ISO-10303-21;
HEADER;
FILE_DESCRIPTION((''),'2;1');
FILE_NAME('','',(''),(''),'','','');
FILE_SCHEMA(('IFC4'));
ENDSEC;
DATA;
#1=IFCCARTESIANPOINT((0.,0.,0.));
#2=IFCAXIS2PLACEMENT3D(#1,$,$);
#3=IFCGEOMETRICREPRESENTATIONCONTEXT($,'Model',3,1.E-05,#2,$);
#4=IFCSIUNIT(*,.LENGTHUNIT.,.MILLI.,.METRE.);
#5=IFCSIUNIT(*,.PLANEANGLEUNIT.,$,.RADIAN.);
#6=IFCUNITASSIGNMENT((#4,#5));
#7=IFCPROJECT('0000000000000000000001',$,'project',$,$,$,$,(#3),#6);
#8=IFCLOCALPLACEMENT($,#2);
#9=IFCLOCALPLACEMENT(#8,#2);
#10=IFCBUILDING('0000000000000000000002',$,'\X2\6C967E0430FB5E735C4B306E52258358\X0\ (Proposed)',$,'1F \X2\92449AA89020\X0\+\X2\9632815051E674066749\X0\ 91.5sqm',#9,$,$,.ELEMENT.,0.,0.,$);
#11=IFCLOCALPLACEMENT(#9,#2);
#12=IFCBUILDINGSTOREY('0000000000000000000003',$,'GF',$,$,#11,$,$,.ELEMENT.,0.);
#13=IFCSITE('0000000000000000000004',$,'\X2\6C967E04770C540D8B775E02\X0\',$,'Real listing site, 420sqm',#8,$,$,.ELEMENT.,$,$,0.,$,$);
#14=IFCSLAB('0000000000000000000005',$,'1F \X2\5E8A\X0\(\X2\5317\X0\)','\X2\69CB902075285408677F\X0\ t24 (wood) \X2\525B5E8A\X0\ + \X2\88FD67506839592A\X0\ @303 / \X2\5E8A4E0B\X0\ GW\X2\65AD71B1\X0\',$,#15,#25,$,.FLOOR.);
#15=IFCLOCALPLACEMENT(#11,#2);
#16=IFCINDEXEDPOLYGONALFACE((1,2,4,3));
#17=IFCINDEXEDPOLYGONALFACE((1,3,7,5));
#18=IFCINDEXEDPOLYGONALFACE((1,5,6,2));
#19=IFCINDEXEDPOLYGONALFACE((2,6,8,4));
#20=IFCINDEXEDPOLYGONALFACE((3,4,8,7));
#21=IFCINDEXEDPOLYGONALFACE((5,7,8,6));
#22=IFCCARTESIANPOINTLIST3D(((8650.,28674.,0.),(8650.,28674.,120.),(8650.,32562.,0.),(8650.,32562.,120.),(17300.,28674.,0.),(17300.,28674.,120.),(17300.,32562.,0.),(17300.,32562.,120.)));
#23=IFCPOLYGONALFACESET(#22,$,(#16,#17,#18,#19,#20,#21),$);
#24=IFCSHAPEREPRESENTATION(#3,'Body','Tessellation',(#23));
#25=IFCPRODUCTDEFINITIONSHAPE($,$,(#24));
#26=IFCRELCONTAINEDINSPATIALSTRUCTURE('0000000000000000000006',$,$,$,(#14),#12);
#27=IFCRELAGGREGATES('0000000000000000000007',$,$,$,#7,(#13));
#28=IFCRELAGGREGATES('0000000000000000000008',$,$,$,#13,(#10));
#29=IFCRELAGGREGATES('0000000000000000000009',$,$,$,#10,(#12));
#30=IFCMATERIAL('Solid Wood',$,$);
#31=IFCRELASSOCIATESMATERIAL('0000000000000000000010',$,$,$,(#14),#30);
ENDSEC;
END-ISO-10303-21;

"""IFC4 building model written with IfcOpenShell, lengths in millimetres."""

from ifc_helpers import new_model, si_unit, frame, frame_2d, origin, place, context, project, spatial, rectangle, extrude, material, element, save


model = new_model("IFC4")

# Units and contexts
model_context = context("Model", 3, precision=1e-05, world=origin())
ifc_project = project(units=[si_unit("LENGTHUNIT", "METRE", prefix="MILLI"), si_unit("PLANEANGLEUNIT", "RADIAN")], contexts=[model_context])

# Site, building, storey
site_placement = place(None, origin())
site = spatial("IfcSite", under=ifc_project, at=site_placement, Name="沖縄県名護市", ObjectType="Real listing site, 420sqm", CompositionType="ELEMENT", RefElevation=0.0)
building_placement = place(site_placement, origin())
building = spatial("IfcBuilding", under=site, at=building_placement, Name="沖縄・平屋の別荘 (Proposed)", ObjectType="1F 鉄骨造+防腐処理杉 91.5sqm", CompositionType="ELEMENT", ElevationOfRefHeight=0.0, ElevationOfTerrain=0.0)
storey_placement = place(building_placement, origin())
storey = spatial("IfcBuildingStorey", under=building, at=storey_placement, Name="GF", CompositionType="ELEMENT", Elevation=0.0)

# Shared definitions
ifc_material_1 = material(Name="Solid Wood")

# Slab
slab_placement = place(storey_placement, frame((4325.0, 14337.0, 0.0)))
element("IfcSlab", 1, at=slab_placement, inside=storey, material=ifc_material_1, Name="1F 床(北)", Description="構造用合板 t24 (wood) 剛床 + 製材根太 @303 / 床下 GW断熱", PredefinedType="FLOOR", context=model_context, shape_type="SweptSolid", body=[
    extrude(rectangle(XDim=8650.0, YDim=3888.0, at=frame_2d((4325.0, 1944.0))), frame((4325.0, 14337.0, 0.0)), (0.0, 0.0, 1.0), 120.0),
])

save(model, "model.ifc")
